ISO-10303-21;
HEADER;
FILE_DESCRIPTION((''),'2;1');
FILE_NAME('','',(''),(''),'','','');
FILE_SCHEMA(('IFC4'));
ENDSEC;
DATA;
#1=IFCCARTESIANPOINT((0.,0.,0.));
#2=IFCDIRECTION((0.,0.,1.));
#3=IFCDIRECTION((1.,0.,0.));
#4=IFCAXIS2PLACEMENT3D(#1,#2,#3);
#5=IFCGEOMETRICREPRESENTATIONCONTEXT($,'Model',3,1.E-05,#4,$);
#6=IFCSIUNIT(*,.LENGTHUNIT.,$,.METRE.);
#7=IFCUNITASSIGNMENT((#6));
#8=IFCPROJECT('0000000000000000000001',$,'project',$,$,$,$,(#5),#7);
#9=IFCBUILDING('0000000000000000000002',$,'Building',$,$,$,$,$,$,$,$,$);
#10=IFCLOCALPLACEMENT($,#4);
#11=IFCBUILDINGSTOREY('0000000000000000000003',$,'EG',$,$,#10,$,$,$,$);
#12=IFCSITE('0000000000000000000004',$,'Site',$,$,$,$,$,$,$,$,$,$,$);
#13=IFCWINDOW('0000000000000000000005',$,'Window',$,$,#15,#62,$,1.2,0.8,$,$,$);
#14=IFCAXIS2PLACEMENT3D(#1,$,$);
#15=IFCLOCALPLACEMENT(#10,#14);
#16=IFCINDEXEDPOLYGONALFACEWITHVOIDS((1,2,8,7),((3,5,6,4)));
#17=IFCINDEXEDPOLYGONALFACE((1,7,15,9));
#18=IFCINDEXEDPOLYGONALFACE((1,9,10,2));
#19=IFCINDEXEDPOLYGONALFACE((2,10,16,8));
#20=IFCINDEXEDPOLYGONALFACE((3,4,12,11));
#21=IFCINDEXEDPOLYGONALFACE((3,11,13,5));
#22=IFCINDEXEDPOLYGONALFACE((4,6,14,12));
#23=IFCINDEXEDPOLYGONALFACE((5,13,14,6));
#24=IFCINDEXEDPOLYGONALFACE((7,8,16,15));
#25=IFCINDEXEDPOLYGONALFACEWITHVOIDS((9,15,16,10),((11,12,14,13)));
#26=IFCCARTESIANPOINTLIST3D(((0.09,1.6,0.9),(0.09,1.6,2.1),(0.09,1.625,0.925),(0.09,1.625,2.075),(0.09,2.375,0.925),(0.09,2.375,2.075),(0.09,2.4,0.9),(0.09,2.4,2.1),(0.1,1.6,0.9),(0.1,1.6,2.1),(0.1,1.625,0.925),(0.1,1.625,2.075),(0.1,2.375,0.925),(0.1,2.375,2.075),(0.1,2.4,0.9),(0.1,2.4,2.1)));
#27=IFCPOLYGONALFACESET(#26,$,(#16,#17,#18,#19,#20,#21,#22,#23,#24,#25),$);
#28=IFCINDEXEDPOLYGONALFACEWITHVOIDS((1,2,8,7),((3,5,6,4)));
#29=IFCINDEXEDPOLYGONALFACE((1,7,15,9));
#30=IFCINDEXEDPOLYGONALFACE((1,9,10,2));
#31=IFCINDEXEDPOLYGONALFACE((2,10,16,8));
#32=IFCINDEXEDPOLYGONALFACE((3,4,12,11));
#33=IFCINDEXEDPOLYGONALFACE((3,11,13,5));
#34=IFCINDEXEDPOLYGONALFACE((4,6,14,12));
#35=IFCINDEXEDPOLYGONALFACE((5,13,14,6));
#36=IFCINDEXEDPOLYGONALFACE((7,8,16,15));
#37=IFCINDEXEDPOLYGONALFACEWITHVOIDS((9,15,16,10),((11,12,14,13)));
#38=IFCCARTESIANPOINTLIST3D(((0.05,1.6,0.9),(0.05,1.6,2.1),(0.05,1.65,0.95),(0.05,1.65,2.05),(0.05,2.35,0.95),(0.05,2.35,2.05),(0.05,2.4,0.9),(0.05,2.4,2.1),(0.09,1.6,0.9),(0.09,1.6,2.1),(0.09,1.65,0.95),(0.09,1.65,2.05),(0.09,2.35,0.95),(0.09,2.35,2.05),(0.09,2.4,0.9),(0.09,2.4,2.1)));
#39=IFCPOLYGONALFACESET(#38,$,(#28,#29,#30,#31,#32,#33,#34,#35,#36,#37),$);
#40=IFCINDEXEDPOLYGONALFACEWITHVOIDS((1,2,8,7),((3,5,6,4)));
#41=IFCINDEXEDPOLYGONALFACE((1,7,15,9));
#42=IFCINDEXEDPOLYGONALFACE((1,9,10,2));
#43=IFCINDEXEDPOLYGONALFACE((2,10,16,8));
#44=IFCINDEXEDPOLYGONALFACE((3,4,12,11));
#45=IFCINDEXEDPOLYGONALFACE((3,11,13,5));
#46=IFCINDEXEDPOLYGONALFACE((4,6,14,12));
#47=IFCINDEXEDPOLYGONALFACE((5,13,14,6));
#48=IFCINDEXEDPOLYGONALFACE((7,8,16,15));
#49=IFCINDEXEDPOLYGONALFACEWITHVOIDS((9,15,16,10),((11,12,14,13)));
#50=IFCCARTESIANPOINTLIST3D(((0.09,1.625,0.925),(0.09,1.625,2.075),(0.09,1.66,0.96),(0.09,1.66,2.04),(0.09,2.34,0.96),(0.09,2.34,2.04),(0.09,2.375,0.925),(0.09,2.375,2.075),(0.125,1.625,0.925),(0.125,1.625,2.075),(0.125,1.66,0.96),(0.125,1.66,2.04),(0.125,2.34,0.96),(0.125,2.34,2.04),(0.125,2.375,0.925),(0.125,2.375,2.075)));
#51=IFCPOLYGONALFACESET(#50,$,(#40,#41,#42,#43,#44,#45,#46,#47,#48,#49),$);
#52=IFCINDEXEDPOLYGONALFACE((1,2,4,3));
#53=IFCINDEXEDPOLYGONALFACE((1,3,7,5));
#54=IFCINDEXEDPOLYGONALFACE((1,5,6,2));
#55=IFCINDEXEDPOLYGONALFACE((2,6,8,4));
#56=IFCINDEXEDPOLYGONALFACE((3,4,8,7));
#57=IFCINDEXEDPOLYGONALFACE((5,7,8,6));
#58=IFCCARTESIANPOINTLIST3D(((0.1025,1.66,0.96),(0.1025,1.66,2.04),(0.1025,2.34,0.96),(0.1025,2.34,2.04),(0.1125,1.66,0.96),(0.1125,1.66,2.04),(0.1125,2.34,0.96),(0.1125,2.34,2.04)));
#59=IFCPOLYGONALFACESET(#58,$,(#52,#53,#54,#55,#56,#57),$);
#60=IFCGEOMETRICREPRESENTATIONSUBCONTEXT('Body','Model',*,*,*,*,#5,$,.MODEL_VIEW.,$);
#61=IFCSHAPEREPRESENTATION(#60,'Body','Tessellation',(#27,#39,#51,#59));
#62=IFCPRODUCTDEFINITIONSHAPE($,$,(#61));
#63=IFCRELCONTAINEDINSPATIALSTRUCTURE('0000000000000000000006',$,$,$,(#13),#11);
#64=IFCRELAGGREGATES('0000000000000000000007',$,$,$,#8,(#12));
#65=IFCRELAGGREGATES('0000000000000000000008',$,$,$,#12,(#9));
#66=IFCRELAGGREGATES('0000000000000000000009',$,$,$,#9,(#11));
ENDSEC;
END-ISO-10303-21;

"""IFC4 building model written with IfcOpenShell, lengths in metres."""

from ifc_helpers import new_model, si_unit, frame, origin_with_axes, place, context, subcontext, project, spatial, line, indexed_curve, outline, extrude, element, save


model = new_model("IFC4")

# Units and contexts
model_context = context("Model", 3, precision=1e-05, world=origin_with_axes())
body_context = subcontext(model_context, "Body", "Model", "MODEL_VIEW")
ifc_project = project(units=[si_unit("LENGTHUNIT", "METRE")], contexts=[model_context])

# Site, building, storey
site = spatial("IfcSite", under=ifc_project, Name="Site")
building = spatial("IfcBuilding", under=site, Name="Building")
storey_placement = place(None, origin_with_axes())
storey = spatial("IfcBuildingStorey", under=building, at=storey_placement, Name="EG")

# Window
for number, where, z_axis, x_axis, name in (
    (1, (0.0, 2.4, 0.9), (0.0, 0.0, 1.0), (0.0, -1.0, 0.0), "Window"),
):
    element("IfcWindow", number, at=place(storey_placement, frame(where, z_axis=z_axis, x_axis=x_axis)), inside=storey, Name=name, OverallHeight=1.2, OverallWidth=0.8, context=body_context, shape_type="SweptSolid", body=[
        extrude(outline(indexed_curve([(0.0, 0.0), (0.8, 0.0), (0.8, 1.2), (0.0, 1.2)], segments=[line(1, 2, 3, 4, 1)]), holes=[indexed_curve([(0.025, 0.025), (0.775, 0.025), (0.775, 1.175), (0.025, 1.175)], segments=[line(1, 2, 3, 4, 1)])]), frame((0.0, 0.09, 0.0), z_axis=(0.0, -1.0, 0.0), x_axis=(1.0, 0.0, 0.0)), (0.0, 0.0, -1.0), 0.01),
        extrude(outline(indexed_curve([(0.0, 0.0), (0.8, 0.0), (0.8, 1.2), (0.0, 1.2)], segments=[line(1, 2, 3, 4, 1)]), holes=[indexed_curve([(0.05, 0.05), (0.75, 0.05), (0.75, 1.15), (0.05, 1.15)], segments=[line(1, 2, 3, 4, 1)])]), frame((0.0, 0.05, 0.0), z_axis=(0.0, -1.0, 0.0), x_axis=(1.0, 0.0, 0.0)), (0.0, 0.0, -1.0), 0.04),
        extrude(outline(indexed_curve([(0.0, 0.0), (0.75, 0.0), (0.75, 1.15), (0.0, 1.15)], segments=[line(1, 2, 3, 4, 1)]), holes=[indexed_curve([(0.035, 0.035), (0.715, 0.035), (0.715, 1.115), (0.035, 1.115)], segments=[line(1, 2, 3, 4, 1)])]), frame((0.025, 0.09, 0.025), z_axis=(0.0, -1.0, 0.0), x_axis=(1.0, 0.0, 0.0)), (0.0, 0.0, -1.0), 0.035),
        extrude(outline(indexed_curve([(0.035, 0.035), (0.715, 0.035), (0.715, 1.115), (0.035, 1.115)], segments=[line(1, 2, 3, 4, 1)])), frame((0.025, 0.1025, 0.025), z_axis=(0.0, -1.0, 0.0), x_axis=(1.0, 0.0, 0.0)), (0.0, 0.0, -1.0), 0.01),
    ])

save(model, "model.ifc")
